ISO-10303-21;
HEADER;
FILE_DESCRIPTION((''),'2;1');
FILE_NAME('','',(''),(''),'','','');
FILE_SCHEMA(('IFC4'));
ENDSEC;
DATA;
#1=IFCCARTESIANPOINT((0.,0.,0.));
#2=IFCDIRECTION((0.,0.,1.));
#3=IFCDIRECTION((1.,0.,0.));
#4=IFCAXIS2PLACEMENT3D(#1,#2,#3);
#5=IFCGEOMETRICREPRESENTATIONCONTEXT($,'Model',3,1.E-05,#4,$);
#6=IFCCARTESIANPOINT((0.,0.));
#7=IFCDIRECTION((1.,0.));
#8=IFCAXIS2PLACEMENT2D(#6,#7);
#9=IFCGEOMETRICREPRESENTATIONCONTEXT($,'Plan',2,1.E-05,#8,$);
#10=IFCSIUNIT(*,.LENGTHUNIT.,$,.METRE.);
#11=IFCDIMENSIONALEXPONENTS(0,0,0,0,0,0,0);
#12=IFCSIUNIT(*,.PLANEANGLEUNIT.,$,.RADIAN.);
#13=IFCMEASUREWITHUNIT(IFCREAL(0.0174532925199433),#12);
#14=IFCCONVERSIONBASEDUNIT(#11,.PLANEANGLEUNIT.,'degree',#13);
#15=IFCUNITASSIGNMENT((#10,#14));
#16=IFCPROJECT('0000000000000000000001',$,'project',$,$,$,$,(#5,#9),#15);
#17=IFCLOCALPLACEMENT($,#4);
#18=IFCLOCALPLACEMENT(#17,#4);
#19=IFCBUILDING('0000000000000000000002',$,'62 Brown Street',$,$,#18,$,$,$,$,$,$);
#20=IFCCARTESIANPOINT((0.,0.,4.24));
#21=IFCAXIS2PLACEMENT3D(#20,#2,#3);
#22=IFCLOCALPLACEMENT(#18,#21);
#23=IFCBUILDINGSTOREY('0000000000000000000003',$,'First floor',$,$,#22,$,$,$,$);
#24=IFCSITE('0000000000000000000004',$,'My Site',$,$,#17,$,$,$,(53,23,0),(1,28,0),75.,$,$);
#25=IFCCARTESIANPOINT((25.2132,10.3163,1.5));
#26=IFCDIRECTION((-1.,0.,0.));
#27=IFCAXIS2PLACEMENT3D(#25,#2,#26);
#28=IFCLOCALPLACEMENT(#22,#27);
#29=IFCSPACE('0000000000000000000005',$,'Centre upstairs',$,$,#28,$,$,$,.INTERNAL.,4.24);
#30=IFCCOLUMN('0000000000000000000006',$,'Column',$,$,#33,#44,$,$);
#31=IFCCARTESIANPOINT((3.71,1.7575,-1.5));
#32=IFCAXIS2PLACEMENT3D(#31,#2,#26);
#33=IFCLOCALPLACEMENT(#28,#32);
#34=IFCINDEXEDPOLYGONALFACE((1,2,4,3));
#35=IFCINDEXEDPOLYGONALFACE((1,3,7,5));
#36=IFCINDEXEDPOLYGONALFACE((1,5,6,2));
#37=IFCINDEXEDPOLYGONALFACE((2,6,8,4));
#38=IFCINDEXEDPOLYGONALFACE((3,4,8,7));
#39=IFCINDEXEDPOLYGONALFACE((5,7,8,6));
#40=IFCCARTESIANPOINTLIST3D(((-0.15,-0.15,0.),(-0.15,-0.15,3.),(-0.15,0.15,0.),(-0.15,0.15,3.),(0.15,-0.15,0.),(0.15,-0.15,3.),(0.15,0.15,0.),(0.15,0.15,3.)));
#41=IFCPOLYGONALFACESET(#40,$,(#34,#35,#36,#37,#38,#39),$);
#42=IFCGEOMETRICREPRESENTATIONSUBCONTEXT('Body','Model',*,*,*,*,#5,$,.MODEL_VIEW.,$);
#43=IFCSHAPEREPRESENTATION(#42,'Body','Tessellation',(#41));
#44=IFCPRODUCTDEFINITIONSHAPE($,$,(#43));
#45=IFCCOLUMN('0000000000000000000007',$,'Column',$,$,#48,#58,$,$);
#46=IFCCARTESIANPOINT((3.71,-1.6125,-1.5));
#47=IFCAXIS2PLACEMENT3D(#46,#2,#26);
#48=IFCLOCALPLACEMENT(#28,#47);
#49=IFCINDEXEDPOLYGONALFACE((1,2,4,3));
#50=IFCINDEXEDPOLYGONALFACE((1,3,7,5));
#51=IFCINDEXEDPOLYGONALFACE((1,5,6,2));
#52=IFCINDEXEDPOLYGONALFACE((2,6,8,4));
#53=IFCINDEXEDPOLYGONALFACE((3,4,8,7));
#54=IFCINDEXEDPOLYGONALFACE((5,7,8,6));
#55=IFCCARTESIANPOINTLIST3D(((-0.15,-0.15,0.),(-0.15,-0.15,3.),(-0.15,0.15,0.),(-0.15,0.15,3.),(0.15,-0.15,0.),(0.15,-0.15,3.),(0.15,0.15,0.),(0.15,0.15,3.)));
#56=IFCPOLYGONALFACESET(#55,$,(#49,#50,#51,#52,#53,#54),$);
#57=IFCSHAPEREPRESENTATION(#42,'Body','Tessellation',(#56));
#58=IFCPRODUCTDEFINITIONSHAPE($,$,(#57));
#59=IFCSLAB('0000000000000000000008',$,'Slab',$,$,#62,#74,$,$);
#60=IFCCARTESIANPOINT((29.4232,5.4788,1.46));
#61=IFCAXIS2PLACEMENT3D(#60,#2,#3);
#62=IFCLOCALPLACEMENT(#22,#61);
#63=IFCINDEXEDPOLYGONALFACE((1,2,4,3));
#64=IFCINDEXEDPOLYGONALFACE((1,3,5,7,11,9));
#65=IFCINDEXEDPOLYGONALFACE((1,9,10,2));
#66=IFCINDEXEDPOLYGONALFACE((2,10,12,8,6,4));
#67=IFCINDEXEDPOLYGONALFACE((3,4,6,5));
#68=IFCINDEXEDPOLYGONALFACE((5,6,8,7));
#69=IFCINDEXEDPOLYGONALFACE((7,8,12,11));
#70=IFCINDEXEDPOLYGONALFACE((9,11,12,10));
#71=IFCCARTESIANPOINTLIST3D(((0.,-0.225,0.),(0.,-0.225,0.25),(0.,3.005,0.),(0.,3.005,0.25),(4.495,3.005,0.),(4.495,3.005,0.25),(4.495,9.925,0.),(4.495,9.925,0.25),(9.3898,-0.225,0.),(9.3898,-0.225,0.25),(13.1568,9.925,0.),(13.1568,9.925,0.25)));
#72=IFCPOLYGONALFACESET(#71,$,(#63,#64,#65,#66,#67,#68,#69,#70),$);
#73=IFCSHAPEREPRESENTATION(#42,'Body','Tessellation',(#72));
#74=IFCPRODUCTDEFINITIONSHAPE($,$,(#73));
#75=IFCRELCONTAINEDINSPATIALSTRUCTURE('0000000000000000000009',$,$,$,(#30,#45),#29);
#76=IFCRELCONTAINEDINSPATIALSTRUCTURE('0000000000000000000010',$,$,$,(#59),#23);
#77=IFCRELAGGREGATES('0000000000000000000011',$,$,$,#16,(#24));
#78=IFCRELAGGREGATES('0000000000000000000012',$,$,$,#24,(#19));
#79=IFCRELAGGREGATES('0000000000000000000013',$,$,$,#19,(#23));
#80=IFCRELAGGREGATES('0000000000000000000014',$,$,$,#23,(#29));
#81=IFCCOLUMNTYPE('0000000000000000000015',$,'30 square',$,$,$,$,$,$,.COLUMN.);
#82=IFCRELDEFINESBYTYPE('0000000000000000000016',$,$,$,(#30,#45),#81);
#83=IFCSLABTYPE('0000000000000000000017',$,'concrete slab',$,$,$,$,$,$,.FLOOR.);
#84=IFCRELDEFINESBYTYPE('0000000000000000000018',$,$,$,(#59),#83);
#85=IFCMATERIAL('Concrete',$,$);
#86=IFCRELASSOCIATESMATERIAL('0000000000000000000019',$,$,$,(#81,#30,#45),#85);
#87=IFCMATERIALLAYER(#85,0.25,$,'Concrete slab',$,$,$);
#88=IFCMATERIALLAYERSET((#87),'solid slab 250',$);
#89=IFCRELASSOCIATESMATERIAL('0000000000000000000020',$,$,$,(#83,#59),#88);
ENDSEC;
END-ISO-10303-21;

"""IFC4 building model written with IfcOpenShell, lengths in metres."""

from ifc_helpers import new_model, entity, si_unit, converted_unit, frame, origin_with_axes, origin_2d_with_axis, place, context, subcontext, project, spatial, line, indexed_curve, rectangle, outline, extrude, material, layer, layer_set, layer_usage, material_profile, profile_set, profile_usage, type_object, element, save


model = new_model("IFC4")

# Units and contexts
model_context = context("Model", 3, precision=1e-05, world=origin_with_axes())
plan_context = context("Plan", 2, precision=1e-05, world=origin_2d_with_axis())
body_context_1 = subcontext(model_context, "Body", "Model", "MODEL_VIEW")
ifc_project = project(units=[si_unit("LENGTHUNIT", "METRE"), converted_unit("PLANEANGLEUNIT", "degree", entity("IfcReal", 0.0174532925199433), si_unit("PLANEANGLEUNIT", "RADIAN"), dimensions=[0, 0, 0, 0, 0, 0, 0])], contexts=[model_context, plan_context])

# Site, building, storey, space
site_placement = place(None, origin_with_axes())
site = spatial("IfcSite", under=ifc_project, at=site_placement, Name="My Site", RefLatitude=(53, 23, 0), RefLongitude=(1, 28, 0), RefElevation=75.0)
building_placement = place(site_placement, origin_with_axes())
building = spatial("IfcBuilding", under=site, at=building_placement, Name="62 Brown Street")
storey_placement = place(building_placement, frame((0.0, 0.0, 4.24), z_axis=(0.0, 0.0, 1.0), x_axis=(1.0, 0.0, 0.0)))
storey = spatial("IfcBuildingStorey", under=building, at=storey_placement, Name="First floor")
space_placement = place(storey_placement, frame((25.2132, 10.3163, 1.5), z_axis=(0.0, 0.0, 1.0), x_axis=(-1.0, 0.0, 0.0)))
space = spatial("IfcSpace", under=storey, at=space_placement, Name="Centre upstairs", PredefinedType="INTERNAL", ElevationWithFlooring=4.24)

# Columns
ifc_material_1 = material(Name="Concrete")
ifc_material_profile = material_profile(ifc_material_1, rectangle(XDim=0.3, YDim=0.3))
ifc_profile_set = profile_set([ifc_material_profile])
ifc_profile_usage_1 = profile_usage(ifc_profile_set, cardinal=5)
column_type = type_object("IfcColumnType", Name="30 square", PredefinedType="COLUMN", material=ifc_profile_set)
column_1_placement = place(space_placement, frame((3.71, 1.7575, -1.5), z_axis=(0.0, 0.0, 1.0), x_axis=(-1.0, 0.0, 0.0)))
element("IfcColumn", 1, at=column_1_placement, inside=space, type_object=column_type, material=ifc_profile_usage_1, Name="Column", context=body_context_1, shape_type="SweptSolid", body=[
    extrude(rectangle(XDim=0.3, YDim=0.3), origin_with_axes(), (0.0, 0.0, 1.0), 3.0),
])
ifc_profile_usage_2 = profile_usage(ifc_profile_set, cardinal=5)
column_2_placement = place(space_placement, frame((3.71, -1.6125, -1.5), z_axis=(0.0, 0.0, 1.0), x_axis=(-1.0, 0.0, 0.0)))
element("IfcColumn", 2, at=column_2_placement, inside=space, type_object=column_type, material=ifc_profile_usage_2, Name="Column", context=body_context_1, shape_type="SweptSolid", body=[
    extrude(rectangle(XDim=0.3, YDim=0.3), origin_with_axes(), (0.0, 0.0, 1.0), 3.0),
])

# Slab
ifc_layer_1 = layer(ifc_material_1, 0.25, Name="Concrete slab")
ifc_layer_set_1 = layer_set([ifc_layer_1], Name="solid slab 250")
slab_type = type_object("IfcSlabType", Name="concrete slab", PredefinedType="FLOOR", material=ifc_layer_set_1)
ifc_layer_usage_1 = layer_usage(ifc_layer_set_1, "AXIS3", "POSITIVE", 0.0)
slab_1_placement = place(storey_placement, frame((29.4232, 5.4788, 1.46), z_axis=(0.0, 0.0, 1.0), x_axis=(1.0, 0.0, 0.0)))
element("IfcSlab", 3, at=slab_1_placement, inside=storey, type_object=slab_type, material=ifc_layer_usage_1, Name="Slab", context=body_context_1, shape_type="SweptSolid", body=[
    extrude(outline(indexed_curve([(0.0, 3.005), (0.0, -0.225), (9.3898, -0.225), (13.1568, 9.925), (4.495, 9.925), (4.495, 3.005)], segments=[line(4, 3), line(3, 2), line(2, 1), line(1, 6), line(6, 5), line(5, 4)], self_intersect=False)), None, (0.0, 0.0, 1.0), 0.25),
])

save(model, "model.ifc")
